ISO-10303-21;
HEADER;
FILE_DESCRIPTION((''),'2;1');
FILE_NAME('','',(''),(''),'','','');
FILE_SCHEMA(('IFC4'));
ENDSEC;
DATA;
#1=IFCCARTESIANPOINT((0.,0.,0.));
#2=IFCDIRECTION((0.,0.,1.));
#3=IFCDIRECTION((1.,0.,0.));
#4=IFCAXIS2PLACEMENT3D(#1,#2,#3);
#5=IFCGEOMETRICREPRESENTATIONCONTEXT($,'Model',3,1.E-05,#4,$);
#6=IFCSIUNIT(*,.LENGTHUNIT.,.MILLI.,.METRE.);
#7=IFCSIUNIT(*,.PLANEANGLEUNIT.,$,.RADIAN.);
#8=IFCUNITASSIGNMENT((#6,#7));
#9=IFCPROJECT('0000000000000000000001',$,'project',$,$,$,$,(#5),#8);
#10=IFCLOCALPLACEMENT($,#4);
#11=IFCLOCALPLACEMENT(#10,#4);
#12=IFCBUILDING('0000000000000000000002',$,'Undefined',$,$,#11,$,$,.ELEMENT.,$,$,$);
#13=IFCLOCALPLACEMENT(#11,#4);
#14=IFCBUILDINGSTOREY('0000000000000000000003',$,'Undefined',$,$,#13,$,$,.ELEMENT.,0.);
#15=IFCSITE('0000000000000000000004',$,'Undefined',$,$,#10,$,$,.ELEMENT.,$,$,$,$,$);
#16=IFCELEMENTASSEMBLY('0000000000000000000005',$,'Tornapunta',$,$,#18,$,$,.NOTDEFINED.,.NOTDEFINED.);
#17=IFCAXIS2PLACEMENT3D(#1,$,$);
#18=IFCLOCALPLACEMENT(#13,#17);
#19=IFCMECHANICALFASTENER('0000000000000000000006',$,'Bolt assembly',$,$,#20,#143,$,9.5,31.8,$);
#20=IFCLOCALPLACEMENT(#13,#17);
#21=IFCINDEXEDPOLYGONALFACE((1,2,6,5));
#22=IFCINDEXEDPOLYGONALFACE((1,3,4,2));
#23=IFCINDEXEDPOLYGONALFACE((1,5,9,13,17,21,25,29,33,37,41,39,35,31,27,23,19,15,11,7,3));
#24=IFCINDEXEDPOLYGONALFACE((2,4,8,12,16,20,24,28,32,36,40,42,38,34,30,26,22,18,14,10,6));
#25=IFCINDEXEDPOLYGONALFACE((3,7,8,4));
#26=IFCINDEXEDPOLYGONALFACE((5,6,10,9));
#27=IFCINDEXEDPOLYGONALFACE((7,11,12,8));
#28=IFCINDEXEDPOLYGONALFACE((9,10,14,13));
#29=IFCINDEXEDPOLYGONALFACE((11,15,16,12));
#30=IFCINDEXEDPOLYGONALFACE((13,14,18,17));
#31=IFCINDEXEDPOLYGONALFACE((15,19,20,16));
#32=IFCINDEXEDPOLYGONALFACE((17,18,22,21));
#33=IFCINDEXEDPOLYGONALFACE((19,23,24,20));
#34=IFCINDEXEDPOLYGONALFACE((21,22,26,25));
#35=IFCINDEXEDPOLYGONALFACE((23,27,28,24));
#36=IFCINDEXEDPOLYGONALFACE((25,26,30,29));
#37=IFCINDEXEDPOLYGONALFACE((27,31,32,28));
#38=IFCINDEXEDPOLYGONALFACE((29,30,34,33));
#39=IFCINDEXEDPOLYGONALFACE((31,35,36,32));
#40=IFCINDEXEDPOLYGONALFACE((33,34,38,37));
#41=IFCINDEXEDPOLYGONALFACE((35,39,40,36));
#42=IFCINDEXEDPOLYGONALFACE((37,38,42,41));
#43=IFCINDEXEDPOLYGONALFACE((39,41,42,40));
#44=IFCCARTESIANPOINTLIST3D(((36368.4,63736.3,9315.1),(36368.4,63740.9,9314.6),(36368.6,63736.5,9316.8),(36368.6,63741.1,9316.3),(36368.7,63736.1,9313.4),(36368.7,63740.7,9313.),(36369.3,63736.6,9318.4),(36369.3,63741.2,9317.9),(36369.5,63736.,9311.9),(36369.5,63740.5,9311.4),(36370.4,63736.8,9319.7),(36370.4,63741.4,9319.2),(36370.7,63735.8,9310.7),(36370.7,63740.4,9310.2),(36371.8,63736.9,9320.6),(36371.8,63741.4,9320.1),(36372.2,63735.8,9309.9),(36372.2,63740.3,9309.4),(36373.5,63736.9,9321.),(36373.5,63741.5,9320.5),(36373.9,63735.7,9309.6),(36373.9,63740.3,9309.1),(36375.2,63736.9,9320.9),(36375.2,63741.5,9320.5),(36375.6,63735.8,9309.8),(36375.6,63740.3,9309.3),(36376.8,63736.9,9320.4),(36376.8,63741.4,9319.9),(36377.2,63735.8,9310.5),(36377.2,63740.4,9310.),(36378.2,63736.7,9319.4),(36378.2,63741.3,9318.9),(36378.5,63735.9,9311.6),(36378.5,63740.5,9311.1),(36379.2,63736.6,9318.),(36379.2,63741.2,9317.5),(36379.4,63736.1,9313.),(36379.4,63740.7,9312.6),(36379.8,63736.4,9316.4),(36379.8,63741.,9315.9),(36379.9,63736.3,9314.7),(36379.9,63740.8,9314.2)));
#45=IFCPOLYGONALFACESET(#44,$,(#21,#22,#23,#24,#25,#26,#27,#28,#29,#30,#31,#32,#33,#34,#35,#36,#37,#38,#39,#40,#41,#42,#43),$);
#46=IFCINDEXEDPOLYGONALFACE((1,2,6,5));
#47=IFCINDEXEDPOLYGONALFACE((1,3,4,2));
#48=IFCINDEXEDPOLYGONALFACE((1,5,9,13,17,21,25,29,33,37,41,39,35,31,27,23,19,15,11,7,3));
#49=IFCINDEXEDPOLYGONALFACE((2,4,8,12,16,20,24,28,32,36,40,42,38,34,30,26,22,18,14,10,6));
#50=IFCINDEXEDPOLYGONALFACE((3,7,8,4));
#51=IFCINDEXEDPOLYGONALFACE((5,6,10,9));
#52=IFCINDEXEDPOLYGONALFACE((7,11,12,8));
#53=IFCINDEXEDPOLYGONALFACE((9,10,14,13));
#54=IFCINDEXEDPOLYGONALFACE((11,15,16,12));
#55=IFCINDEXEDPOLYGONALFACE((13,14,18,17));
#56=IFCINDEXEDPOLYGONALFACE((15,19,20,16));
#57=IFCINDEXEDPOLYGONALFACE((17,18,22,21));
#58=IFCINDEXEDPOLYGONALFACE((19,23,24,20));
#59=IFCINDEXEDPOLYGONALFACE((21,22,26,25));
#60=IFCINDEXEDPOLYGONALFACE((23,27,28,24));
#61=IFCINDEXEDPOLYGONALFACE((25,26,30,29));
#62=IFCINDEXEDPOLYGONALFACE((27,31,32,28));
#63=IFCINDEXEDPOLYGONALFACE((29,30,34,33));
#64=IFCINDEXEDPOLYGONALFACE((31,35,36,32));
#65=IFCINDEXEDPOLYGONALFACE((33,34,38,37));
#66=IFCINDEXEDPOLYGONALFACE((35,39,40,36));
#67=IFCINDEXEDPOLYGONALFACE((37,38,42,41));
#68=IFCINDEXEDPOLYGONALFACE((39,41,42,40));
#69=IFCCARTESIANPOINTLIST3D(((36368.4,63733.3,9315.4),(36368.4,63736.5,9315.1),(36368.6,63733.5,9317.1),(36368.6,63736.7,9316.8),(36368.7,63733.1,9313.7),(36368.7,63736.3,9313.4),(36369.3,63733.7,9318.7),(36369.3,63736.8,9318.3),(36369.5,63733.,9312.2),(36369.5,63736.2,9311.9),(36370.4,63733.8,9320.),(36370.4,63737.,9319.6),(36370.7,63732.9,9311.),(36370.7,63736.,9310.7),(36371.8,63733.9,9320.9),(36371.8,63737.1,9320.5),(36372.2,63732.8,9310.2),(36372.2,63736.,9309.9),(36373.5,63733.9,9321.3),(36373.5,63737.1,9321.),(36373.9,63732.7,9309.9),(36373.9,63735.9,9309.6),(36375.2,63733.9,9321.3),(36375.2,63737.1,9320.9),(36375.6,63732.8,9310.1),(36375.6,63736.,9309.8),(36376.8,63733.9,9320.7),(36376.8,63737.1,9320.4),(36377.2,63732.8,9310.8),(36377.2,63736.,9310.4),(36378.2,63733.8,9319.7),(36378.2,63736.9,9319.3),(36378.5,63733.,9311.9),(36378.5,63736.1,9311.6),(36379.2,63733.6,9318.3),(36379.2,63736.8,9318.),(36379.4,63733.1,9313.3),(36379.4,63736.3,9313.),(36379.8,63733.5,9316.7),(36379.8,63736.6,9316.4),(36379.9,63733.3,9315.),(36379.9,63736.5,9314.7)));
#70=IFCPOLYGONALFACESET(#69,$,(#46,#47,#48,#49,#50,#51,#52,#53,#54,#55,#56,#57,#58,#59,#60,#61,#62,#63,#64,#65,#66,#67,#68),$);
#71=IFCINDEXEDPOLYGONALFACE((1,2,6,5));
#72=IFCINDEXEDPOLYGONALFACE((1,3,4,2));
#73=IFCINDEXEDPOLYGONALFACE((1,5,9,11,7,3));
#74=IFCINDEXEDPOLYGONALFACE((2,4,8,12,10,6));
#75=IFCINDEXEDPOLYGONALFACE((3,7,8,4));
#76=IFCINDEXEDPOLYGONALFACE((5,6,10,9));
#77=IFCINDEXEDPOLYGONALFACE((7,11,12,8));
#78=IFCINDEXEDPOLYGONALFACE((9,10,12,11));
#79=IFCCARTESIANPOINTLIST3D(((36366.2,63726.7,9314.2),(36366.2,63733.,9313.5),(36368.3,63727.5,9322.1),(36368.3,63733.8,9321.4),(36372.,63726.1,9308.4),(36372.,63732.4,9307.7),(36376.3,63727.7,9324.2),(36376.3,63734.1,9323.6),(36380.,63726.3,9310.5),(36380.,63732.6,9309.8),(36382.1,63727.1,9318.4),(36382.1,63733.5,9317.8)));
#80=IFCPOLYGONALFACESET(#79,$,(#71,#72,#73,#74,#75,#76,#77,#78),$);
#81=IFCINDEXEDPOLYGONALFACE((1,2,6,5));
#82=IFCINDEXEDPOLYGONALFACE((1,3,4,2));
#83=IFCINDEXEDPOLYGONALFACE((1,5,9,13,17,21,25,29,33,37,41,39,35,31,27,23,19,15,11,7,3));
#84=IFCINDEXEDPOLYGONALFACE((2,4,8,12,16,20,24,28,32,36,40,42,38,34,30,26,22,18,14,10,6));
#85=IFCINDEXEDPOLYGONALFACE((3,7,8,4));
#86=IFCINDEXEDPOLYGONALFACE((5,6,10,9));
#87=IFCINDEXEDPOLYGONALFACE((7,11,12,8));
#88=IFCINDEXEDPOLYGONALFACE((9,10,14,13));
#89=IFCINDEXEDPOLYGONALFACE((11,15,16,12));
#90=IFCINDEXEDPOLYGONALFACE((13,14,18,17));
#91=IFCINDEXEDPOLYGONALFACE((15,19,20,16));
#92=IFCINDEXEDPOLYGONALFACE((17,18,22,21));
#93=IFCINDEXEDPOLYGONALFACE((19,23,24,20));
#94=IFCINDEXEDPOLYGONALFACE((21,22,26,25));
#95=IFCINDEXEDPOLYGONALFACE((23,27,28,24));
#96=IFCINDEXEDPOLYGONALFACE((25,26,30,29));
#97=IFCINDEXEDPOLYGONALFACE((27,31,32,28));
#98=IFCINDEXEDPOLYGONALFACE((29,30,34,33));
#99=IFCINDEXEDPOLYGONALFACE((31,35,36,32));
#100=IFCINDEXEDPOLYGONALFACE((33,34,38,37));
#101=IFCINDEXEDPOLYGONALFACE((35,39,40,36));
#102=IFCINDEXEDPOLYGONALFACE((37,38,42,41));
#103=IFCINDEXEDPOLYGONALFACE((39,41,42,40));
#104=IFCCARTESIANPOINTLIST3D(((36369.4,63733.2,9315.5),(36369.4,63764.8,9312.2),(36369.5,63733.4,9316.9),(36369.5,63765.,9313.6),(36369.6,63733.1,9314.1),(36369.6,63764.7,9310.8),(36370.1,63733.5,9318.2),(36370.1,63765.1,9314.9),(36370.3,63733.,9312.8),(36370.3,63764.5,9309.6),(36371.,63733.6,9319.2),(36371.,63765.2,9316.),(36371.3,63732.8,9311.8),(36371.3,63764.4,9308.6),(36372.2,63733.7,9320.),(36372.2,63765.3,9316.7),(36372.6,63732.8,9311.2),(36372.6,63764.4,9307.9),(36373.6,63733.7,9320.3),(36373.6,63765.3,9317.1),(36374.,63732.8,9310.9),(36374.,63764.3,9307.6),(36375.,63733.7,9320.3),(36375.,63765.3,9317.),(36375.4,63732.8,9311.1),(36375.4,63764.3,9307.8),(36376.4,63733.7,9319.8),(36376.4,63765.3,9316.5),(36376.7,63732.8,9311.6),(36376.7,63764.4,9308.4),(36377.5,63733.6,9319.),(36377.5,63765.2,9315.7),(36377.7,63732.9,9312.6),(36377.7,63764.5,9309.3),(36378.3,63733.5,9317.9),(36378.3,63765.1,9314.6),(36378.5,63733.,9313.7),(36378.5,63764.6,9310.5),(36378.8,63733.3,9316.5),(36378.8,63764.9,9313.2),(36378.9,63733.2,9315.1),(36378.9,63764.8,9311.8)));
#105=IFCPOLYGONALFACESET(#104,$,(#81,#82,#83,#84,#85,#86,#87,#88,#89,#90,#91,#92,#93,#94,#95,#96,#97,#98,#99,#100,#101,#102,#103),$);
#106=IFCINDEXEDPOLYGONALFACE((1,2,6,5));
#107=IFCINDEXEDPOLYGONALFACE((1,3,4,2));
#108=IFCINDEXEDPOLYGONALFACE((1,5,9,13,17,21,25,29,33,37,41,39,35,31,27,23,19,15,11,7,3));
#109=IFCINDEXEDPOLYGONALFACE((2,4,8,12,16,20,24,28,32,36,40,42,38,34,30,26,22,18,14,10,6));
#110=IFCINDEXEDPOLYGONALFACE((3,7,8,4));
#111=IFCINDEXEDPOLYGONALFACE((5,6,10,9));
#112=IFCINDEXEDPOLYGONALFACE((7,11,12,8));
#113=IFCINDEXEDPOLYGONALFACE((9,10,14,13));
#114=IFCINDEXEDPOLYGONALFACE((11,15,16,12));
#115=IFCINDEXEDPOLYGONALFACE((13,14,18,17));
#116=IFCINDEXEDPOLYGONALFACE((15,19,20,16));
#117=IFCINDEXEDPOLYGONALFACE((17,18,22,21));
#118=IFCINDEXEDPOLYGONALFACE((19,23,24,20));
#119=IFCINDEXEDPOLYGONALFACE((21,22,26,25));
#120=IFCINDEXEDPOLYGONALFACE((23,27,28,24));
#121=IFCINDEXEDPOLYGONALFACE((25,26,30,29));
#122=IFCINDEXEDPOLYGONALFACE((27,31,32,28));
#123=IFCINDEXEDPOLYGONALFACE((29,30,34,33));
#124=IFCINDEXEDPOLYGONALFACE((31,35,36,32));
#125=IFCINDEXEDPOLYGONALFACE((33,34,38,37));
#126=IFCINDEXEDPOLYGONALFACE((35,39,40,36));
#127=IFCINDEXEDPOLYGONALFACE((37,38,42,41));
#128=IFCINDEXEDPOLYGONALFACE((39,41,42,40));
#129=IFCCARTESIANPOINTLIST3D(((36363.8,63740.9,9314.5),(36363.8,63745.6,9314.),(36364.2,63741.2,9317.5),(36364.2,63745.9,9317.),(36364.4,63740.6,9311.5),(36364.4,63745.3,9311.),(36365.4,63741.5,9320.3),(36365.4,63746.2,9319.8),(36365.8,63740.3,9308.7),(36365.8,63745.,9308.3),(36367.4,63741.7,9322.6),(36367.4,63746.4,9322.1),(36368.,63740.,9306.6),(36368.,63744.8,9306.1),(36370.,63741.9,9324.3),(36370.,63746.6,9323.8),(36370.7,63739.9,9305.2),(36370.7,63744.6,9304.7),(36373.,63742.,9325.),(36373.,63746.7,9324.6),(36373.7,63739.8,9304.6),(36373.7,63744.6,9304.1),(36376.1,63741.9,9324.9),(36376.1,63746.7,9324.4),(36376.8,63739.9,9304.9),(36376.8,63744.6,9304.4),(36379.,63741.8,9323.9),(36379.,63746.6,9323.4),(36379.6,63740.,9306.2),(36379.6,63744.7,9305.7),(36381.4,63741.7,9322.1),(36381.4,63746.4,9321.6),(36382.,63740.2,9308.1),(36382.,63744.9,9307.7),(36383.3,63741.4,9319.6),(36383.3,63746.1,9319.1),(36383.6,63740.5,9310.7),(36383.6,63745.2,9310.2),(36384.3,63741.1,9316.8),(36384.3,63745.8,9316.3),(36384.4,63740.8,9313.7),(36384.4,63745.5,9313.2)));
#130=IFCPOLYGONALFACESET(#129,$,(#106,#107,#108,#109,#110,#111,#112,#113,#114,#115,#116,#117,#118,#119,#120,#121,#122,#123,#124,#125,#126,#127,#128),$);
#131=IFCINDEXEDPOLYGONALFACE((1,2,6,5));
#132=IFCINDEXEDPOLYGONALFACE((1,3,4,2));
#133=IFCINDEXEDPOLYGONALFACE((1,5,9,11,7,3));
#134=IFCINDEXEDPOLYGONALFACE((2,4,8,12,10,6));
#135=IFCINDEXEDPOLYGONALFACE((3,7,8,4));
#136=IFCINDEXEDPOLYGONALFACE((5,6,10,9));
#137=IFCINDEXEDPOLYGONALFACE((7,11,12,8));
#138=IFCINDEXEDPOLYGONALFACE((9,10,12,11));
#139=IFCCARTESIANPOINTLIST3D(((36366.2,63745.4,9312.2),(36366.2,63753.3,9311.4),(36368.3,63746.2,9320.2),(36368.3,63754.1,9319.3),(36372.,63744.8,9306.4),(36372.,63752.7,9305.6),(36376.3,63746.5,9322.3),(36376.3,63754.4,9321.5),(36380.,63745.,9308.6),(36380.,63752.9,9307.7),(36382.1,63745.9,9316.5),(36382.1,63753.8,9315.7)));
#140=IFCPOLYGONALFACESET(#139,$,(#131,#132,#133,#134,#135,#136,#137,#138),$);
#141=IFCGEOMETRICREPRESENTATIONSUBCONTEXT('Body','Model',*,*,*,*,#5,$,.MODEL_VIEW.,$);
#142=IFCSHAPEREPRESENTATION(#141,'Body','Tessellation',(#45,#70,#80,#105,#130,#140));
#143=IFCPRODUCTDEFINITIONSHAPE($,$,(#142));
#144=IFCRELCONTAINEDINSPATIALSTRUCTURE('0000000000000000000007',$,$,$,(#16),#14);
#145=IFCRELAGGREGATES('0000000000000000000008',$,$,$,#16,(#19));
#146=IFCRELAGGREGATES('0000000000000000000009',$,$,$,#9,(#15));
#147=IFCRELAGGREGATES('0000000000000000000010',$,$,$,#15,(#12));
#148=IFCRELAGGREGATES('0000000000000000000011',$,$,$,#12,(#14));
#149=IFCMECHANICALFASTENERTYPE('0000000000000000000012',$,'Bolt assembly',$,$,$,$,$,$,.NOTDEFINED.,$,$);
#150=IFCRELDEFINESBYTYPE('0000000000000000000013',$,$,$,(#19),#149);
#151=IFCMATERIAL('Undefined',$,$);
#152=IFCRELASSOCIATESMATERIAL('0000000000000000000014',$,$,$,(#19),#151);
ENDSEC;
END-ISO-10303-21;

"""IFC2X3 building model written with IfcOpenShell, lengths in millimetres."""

from ifc_helpers import new_model, si_unit, frame, origin_with_axes, origin_2d_with_axis, place, context, subcontext, project, spatial, polyline, circle, outline, extrude, source, transform, mapped, material, type_object, element, aggregate, save


model = new_model("IFC2X3")

# Units and contexts
model_context = context("Model", 3, precision=1e-05, world=origin_with_axes())
body_context = subcontext(model_context, "Body", "Model", "MODEL_VIEW")
ifc_project = project(units=[si_unit("LENGTHUNIT", "METRE", prefix="MILLI"), si_unit("PLANEANGLEUNIT", "RADIAN")], contexts=[model_context])

# Site, building, storey
site_placement = place(None, origin_with_axes())
site = spatial("IfcSite", under=ifc_project, at=site_placement, Name="Undefined", CompositionType="ELEMENT")
building_placement = place(site_placement, origin_with_axes())
building = spatial("IfcBuilding", under=site, at=building_placement, Name="Undefined", CompositionType="ELEMENT")
storey_placement = place(building_placement, origin_with_axes())
storey = spatial("IfcBuildingStorey", under=building, at=storey_placement, Name="Undefined", CompositionType="ELEMENT", Elevation=0.0)

# Element assembly
assembly_1_placement = place(storey_placement, origin_with_axes())
assembly_1 = element("IfcElementAssembly", 1, at=assembly_1_placement, inside=storey, Name="Tornapunta", AssemblyPlace="NOTDEFINED", PredefinedType="NOTDEFINED")

# Shared definitions
ifc_material_1 = material(Name="Undefined")
mechanical_fastener_type = type_object("IfcMechanicalFastenerType", Name="Bolt assembly")

# Mechanical fastener
shared_shape_1 = source(origin_with_axes(), body_context, "Body", "SweptSolid", [
    extrude(circle(Radius=5.8, at=origin_2d_with_axis()), frame((0.0, -0.1, 0.0), z_axis=(0.0, 1.0, 0.0), x_axis=(1.0, 0.0, 0.0)), (0.0, 0.0, 1.0), 4.6),
    extrude(circle(Radius=5.8, at=origin_2d_with_axis()), frame((0.0, -3.1, 0.0), z_axis=(0.0, 1.0, 0.0), x_axis=(1.0, 0.0, 0.0)), (0.0, 0.0, 1.0), 3.2),
    extrude(outline(polyline([(7.1, -4.1), (7.1, 4.1), (0.0, 8.2), (-7.1, 4.1), (-7.1, -4.1), (0.0, -8.2), (7.1, -4.1)])), frame((0.0, -9.5, 0.0), z_axis=(0.0, 1.0, 0.0), x_axis=(1.0, 0.0, 0.0)), (0.0, 0.0, 1.0), 6.3),
    extrude(circle(Radius=4.8, at=origin_2d_with_axis()), frame((0.0, -3.2, 0.0), z_axis=(0.0, 1.0, 0.0), x_axis=(1.0, 0.0, 0.0)), (0.0, 0.0, 1.0), 31.8),
    extrude(circle(Radius=10.3, at=origin_2d_with_axis()), frame((0.0, 4.5, 0.0), z_axis=(0.0, 1.0, 0.0), x_axis=(1.0, 0.0, 0.0)), (0.0, 0.0, 1.0), 4.8),
    extrude(outline(polyline([(7.1, -4.1), (7.1, 4.1), (0.0, 8.2), (-7.1, 4.1), (-7.1, -4.1), (0.0, -8.2), (7.1, -4.1)])), frame((0.0, 9.3, 0.0), z_axis=(0.0, 1.0, 0.0), x_axis=(1.0, 0.0, 0.0)), (0.0, 0.0, 1.0), 7.9),
])
mechanical_fastener_1_placement = place(assembly_1_placement, frame((36374.1, 63736.4, 9315.3), z_axis=(-0.707107, 0.072947, 0.703334), x_axis=(0.707107, 0.072947, 0.703334)))
mechanical_fastener_1 = element("IfcMechanicalFastener", 2, at=mechanical_fastener_1_placement, type_object=mechanical_fastener_type, material=ifc_material_1, Name="Bolt assembly", NominalDiameter=9.5, NominalLength=31.8, context=body_context, shape_type="MappedRepresentation", body=[
    mapped(shared_shape_1, transform((0.0, 0.0, 0.0))),
])
aggregate(assembly_1, [mechanical_fastener_1])

save(model, "model.ifc")
